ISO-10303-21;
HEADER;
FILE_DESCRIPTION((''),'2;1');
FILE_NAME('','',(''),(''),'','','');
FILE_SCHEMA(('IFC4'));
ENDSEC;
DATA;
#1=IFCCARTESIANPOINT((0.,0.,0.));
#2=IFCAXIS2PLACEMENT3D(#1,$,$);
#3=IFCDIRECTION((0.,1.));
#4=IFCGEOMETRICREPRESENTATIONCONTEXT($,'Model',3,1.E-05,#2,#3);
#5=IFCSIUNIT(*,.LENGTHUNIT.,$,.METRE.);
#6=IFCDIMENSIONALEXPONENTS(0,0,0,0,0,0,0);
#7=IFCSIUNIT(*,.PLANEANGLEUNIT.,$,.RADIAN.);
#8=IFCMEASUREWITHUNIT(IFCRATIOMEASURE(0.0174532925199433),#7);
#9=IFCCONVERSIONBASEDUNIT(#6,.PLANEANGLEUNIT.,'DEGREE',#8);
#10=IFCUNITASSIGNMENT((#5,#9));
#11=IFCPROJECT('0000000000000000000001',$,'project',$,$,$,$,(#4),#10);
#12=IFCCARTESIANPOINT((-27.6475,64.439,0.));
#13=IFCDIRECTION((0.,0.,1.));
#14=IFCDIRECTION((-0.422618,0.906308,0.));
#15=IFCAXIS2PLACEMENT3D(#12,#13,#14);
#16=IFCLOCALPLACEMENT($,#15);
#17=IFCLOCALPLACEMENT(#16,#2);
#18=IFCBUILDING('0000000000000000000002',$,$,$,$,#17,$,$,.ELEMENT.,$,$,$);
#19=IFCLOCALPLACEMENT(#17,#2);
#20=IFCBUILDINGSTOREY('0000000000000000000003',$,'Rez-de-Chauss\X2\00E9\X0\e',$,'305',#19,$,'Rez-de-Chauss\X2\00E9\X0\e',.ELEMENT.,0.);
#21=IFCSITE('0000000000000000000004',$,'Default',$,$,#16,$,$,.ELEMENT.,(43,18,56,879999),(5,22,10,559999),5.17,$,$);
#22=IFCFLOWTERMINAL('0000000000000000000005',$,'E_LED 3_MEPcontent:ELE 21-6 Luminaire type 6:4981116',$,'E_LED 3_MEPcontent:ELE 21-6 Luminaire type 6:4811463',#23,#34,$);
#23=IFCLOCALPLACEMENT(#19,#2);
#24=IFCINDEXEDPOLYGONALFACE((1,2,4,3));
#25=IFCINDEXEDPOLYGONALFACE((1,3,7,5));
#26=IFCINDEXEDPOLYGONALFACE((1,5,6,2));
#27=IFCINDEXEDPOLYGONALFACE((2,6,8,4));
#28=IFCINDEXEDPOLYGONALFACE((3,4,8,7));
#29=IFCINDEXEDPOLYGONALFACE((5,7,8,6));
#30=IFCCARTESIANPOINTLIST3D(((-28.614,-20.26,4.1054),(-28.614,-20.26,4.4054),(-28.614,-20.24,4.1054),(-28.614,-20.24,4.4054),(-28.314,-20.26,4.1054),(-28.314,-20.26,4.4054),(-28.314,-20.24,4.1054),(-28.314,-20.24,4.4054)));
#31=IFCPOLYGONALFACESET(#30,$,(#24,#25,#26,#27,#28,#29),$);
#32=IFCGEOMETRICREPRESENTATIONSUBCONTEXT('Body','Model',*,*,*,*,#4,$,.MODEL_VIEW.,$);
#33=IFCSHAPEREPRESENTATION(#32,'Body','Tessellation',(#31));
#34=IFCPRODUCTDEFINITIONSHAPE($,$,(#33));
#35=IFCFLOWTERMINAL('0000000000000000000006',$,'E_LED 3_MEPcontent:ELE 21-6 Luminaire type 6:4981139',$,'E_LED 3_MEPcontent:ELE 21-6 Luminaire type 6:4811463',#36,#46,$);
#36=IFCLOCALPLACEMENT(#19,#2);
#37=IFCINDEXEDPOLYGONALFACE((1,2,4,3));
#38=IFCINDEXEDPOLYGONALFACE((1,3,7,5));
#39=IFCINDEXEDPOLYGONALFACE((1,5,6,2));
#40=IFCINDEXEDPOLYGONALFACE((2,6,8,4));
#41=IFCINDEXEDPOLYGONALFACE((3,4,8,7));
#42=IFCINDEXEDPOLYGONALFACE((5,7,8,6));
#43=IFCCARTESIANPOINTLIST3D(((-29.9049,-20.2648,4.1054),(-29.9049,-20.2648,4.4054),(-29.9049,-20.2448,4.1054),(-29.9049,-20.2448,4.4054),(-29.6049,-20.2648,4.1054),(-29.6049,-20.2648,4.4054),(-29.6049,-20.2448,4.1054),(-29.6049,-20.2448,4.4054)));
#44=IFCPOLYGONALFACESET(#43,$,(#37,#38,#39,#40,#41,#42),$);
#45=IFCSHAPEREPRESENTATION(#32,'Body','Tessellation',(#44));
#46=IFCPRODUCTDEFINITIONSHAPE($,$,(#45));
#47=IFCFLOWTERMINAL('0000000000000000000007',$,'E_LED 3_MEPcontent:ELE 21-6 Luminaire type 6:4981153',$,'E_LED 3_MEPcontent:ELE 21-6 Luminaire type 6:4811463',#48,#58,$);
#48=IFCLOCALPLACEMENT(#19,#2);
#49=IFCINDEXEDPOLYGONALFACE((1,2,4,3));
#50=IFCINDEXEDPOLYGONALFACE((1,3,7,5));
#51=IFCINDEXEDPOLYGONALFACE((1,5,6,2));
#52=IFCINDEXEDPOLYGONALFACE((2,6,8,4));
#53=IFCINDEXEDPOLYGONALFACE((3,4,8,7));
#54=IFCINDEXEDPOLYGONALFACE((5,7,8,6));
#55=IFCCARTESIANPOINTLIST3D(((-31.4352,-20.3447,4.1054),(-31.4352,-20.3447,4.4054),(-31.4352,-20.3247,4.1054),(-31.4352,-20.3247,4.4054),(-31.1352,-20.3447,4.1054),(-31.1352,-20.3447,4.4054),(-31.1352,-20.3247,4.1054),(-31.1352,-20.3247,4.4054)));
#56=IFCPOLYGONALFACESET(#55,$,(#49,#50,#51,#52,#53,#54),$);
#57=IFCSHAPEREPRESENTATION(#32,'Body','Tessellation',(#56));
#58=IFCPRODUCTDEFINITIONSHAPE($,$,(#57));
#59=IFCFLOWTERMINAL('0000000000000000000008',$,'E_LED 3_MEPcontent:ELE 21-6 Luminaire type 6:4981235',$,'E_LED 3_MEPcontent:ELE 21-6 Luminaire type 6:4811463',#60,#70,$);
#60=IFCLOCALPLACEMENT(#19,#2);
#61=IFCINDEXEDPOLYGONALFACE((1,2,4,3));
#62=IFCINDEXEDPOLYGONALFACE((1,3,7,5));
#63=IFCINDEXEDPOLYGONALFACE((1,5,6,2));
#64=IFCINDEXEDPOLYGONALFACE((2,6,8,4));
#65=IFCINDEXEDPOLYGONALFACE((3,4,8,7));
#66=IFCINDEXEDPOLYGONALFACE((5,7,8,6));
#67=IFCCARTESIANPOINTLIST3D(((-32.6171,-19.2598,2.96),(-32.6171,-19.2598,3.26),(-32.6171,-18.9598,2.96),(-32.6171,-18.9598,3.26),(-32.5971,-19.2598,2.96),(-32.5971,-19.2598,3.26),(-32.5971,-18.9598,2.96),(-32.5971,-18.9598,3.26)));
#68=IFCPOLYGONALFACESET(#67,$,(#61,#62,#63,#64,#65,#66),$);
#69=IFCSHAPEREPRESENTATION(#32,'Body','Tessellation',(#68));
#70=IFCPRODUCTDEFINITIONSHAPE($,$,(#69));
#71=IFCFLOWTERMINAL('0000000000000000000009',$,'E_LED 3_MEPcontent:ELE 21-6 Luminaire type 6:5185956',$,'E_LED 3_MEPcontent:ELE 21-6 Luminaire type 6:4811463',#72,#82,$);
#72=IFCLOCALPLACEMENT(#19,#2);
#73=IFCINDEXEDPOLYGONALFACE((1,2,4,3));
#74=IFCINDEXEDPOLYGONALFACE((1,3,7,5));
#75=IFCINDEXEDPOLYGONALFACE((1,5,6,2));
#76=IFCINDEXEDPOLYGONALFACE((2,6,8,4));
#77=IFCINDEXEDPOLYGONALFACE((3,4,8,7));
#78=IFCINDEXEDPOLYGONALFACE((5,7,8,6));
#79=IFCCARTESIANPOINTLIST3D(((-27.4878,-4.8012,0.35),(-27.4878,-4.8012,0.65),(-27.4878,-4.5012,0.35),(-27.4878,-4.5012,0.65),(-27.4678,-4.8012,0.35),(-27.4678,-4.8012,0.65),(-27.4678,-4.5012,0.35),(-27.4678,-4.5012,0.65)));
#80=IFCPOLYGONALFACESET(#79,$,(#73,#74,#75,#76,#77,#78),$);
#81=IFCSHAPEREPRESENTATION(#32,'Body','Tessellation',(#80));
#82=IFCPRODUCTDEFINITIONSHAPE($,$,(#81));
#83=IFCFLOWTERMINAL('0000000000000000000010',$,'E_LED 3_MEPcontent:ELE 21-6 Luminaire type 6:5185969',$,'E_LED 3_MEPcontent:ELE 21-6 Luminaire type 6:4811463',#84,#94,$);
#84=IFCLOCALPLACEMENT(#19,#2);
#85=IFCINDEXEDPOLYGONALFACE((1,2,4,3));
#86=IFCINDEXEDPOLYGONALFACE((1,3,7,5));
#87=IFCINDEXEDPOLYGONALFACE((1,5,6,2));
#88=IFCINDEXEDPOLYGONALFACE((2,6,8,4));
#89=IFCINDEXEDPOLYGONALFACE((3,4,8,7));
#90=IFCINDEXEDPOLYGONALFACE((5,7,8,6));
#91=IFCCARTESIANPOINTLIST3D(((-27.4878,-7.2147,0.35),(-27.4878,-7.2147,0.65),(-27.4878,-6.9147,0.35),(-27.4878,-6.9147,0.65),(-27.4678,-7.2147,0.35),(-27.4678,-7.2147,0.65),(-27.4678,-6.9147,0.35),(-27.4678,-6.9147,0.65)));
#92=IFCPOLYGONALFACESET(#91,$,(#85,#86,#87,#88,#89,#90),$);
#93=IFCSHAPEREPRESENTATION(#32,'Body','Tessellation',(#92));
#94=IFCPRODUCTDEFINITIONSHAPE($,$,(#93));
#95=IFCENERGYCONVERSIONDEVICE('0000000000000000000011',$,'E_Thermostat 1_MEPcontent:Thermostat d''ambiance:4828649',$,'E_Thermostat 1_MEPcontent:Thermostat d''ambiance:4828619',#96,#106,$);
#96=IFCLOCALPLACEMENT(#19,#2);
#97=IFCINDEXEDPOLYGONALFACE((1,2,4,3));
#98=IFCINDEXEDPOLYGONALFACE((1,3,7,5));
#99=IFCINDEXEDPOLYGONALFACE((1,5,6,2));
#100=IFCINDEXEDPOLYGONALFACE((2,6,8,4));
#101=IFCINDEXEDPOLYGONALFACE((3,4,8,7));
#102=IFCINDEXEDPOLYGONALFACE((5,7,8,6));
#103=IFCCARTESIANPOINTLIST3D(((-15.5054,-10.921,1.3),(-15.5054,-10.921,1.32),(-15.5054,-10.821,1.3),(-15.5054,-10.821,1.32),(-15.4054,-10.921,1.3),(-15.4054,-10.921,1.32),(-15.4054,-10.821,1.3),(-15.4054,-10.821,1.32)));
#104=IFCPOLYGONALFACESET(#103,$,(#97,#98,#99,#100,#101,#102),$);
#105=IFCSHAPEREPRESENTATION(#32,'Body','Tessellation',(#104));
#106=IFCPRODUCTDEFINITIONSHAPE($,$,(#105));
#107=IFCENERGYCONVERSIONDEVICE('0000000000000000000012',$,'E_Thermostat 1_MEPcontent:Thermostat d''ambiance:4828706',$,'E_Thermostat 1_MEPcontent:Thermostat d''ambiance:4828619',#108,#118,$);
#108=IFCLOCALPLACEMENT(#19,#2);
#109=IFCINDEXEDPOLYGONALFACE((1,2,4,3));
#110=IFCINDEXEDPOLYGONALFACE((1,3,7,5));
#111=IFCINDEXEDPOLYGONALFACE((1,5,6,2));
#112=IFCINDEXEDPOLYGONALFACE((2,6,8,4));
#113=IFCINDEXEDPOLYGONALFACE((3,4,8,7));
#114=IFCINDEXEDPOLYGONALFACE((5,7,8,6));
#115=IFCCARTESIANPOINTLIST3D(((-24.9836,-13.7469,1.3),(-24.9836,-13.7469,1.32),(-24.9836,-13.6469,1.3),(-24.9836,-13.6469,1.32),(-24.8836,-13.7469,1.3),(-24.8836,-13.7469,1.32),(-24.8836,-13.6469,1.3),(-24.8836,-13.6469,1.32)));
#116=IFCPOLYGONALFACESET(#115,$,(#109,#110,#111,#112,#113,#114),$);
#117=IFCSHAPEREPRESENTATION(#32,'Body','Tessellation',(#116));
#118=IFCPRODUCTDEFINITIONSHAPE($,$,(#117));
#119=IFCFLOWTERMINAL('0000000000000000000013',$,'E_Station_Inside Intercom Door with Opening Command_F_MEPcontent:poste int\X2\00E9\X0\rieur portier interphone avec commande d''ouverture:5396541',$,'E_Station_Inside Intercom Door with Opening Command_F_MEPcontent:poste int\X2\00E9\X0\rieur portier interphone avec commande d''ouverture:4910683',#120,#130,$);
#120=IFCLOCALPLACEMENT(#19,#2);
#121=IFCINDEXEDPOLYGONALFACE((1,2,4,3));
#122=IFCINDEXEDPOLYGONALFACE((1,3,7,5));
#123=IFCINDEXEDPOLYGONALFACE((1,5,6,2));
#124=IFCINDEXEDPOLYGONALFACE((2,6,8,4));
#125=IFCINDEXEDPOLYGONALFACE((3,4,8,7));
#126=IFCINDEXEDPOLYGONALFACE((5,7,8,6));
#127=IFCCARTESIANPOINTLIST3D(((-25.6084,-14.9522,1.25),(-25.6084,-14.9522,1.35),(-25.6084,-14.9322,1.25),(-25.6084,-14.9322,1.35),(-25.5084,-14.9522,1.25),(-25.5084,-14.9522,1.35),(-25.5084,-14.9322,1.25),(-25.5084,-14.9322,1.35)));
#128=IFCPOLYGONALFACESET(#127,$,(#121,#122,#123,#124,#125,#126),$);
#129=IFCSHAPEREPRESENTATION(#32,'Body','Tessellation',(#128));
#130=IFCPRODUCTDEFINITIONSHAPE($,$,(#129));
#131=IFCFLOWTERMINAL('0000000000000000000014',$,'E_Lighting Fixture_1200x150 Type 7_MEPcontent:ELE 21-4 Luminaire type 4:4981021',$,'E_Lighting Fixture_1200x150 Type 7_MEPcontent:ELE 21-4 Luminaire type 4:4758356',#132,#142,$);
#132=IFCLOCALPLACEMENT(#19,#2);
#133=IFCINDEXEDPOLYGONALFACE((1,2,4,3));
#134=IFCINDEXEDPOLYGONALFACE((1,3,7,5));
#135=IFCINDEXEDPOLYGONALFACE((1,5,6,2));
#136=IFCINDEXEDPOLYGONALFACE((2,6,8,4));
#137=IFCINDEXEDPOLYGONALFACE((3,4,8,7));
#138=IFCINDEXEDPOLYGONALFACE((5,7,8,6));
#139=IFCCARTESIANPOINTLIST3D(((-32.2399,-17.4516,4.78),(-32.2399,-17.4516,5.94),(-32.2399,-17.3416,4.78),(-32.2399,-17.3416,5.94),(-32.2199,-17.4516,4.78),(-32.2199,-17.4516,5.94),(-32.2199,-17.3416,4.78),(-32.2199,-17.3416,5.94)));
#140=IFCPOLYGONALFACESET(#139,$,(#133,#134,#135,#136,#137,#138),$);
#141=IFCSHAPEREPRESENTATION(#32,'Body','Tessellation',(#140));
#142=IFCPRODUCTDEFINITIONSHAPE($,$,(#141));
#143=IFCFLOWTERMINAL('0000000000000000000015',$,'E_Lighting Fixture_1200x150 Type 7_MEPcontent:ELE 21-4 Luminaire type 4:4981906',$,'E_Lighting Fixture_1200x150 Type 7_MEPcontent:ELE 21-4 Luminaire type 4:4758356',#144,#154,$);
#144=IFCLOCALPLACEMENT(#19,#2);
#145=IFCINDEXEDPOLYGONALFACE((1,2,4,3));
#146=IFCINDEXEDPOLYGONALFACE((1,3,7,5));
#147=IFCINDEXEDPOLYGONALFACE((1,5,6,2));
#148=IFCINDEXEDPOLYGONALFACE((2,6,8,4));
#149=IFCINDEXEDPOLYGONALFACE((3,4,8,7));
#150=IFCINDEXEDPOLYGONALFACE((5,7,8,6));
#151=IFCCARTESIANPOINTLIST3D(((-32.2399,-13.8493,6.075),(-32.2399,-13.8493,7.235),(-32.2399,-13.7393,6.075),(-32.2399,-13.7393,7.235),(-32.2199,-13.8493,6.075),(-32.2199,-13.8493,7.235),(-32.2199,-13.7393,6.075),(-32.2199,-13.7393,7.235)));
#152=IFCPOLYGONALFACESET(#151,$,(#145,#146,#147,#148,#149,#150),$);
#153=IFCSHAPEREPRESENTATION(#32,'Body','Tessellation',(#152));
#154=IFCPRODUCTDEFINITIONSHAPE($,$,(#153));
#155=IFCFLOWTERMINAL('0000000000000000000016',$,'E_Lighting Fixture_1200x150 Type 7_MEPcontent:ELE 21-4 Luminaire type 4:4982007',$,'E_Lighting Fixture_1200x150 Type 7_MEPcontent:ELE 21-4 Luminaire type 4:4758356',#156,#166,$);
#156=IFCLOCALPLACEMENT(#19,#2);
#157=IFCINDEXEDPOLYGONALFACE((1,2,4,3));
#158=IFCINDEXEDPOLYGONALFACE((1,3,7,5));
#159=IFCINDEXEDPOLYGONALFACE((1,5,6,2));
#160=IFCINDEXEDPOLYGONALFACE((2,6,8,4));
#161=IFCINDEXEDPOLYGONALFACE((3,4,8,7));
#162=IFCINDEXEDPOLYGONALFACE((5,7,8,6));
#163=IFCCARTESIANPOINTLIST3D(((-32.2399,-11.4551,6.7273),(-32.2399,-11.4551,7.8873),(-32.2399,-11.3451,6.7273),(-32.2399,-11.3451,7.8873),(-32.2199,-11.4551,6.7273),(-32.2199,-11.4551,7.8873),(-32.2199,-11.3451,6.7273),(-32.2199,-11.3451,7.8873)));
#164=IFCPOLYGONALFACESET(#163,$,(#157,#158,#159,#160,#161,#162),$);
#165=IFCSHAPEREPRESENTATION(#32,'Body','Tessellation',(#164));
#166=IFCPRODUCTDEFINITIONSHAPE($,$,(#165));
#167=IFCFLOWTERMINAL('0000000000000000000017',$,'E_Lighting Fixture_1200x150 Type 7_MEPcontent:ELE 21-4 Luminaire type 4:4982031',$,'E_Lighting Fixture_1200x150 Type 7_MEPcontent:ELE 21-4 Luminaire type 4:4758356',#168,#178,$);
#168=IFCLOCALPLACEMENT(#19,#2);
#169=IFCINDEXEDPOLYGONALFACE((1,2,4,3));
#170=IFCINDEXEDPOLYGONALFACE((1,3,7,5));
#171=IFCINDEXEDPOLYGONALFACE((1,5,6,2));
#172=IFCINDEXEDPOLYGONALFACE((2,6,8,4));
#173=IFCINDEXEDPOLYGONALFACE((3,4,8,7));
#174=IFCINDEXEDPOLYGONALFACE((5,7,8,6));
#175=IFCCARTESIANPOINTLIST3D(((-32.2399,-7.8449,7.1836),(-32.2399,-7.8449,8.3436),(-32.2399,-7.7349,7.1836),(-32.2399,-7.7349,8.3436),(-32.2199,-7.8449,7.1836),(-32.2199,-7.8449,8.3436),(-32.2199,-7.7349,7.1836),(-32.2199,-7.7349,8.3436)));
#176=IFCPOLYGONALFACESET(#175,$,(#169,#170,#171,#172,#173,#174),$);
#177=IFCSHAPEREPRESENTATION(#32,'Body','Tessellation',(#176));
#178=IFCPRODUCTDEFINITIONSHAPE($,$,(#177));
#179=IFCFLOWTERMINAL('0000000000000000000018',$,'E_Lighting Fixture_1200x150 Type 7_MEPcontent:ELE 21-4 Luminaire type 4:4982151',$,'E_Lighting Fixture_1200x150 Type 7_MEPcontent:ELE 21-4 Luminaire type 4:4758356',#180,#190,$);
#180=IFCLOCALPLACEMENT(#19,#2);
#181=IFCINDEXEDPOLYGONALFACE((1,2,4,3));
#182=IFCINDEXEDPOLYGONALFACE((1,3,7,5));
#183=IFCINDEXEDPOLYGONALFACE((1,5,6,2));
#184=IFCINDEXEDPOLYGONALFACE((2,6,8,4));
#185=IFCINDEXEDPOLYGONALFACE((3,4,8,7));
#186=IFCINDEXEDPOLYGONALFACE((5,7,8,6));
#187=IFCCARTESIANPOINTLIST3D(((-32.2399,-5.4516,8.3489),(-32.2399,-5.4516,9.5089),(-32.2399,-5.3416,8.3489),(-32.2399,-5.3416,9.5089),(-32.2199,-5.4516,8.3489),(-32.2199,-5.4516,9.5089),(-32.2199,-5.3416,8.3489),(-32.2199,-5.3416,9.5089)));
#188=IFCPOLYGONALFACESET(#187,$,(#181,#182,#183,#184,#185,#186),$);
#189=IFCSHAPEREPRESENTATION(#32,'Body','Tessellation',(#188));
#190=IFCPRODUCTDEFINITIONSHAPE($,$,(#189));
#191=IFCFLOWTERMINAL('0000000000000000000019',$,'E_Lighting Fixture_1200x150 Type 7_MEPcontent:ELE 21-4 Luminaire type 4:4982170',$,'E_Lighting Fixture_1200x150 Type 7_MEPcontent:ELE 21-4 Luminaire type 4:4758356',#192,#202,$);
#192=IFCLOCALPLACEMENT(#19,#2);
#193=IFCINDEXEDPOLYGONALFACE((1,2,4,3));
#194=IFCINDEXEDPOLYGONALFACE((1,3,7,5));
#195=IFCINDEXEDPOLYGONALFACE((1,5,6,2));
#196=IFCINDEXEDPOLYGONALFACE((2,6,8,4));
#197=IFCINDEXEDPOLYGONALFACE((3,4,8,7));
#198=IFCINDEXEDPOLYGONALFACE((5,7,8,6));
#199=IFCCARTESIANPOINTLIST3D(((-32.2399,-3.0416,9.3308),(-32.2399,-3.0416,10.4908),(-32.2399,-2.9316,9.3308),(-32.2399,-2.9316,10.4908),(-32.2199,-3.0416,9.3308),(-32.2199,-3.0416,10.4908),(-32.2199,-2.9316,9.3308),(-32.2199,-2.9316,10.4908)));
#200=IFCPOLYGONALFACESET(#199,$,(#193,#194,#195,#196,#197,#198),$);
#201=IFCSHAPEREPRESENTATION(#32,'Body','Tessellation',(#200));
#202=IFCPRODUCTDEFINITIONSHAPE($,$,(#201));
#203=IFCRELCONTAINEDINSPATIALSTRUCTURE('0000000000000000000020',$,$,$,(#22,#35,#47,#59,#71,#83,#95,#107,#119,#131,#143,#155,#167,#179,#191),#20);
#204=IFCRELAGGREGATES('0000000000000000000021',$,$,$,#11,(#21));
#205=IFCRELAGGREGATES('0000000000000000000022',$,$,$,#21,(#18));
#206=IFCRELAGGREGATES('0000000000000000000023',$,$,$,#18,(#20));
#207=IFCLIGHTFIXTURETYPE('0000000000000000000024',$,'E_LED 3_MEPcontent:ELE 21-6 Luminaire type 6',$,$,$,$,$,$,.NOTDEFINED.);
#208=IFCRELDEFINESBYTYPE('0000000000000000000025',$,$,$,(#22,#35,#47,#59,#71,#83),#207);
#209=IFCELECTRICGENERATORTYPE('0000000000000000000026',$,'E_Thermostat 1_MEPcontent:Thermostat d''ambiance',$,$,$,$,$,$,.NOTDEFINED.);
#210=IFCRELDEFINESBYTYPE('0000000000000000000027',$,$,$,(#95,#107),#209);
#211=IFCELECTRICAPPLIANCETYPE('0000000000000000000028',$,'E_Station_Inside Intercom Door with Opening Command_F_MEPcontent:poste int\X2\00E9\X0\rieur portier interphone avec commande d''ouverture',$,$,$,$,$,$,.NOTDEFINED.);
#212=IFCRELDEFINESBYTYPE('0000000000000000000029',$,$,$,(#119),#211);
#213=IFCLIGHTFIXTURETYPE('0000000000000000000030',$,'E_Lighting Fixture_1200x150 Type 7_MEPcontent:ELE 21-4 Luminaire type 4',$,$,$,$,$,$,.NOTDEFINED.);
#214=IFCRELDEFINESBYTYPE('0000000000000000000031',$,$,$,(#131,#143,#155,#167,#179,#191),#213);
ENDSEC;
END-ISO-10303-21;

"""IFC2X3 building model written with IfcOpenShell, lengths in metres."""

from ifc_helpers import new_model, entity, si_unit, converted_unit, direction, frame, frame_2d, origin, origin_2d_with_axis, place, context, subcontext, project, spatial, rectangle, extrude, source, transform, mapped, type_object, type_shapes, element, save


model = new_model("IFC2X3")

# Units and contexts
model_context = context("Model", 3, precision=1e-05, world=origin(), true_north=direction((0.0, 1.0)))
body_context = subcontext(model_context, "Body", "Model", "MODEL_VIEW")
ifc_project = project(units=[si_unit("LENGTHUNIT", "METRE"), converted_unit("PLANEANGLEUNIT", "DEGREE", entity("IfcRatioMeasure", 0.0174532925199433), si_unit("PLANEANGLEUNIT", "RADIAN"), dimensions=[0, 0, 0, 0, 0, 0, 0])], contexts=[model_context])

# Site, building, storey
site_placement = place(None, frame((-27.6475, 64.439, 0.0), z_axis=(0.0, 0.0, 1.0), x_axis=(-0.422618, 0.906308, 0.0)))
site = spatial("IfcSite", under=ifc_project, at=site_placement, Name="Default", CompositionType="ELEMENT", RefLatitude=(43, 18, 56, 879999), RefLongitude=(5, 22, 10, 559999), RefElevation=5.17)
building_placement = place(site_placement, origin())
building = spatial("IfcBuilding", under=site, at=building_placement, CompositionType="ELEMENT")
storey_placement = place(building_placement, origin())
storey = spatial("IfcBuildingStorey", under=building, at=storey_placement, Name="Rez-de-Chaussée", ObjectType="305", LongName="Rez-de-Chaussée", CompositionType="ELEMENT", Elevation=0.0)

# Flow terminals
light_fixture_type_1 = type_object("IfcLightFixtureType", Name="E_LED 3_MEPcontent:ELE 21-6 Luminaire type 6", PredefinedType="NOTDEFINED")
shared_shape_1 = source(origin(), body_context, "Body", "SweptSolid", [
    extrude(rectangle(XDim=0.02, YDim=0.3, at=origin_2d_with_axis()), frame((0.0, 0.01, -0.15), z_axis=(0.0, 0.0, 1.0), x_axis=(0.0, -1.0, 0.0)), (0.0, 0.0, 1.0), 0.3),
])
type_shapes(light_fixture_type_1, [shared_shape_1])
for number, where, z_axis, x_axis, name in (
    (1, (-28.464, -20.24, 4.2554), (0.0, 0.0, 1.0), (-1.0, 0.0, 0.0), "E_LED 3_MEPcontent:ELE 21-6 Luminaire type 6:4981116"),
    (2, (-29.7549, -20.2448, 4.2554), (0.0, 0.0, 1.0), (-1.0, 0.0, 0.0), "E_LED 3_MEPcontent:ELE 21-6 Luminaire type 6:4981139"),
    (3, (-31.2852, -20.3247, 4.2554), (0.0, 0.0, 1.0), (-1.0, 0.0, 0.0), "E_LED 3_MEPcontent:ELE 21-6 Luminaire type 6:4981153"),
    (4, (-32.6171, -19.1098, 3.11), (0.0, 0.0, 1.0), (0.0, -1.0, 0.0), "E_LED 3_MEPcontent:ELE 21-6 Luminaire type 6:4981235"),
    (5, (-27.4878, -4.6512, 0.5), (0.0, 0.0, 1.0), (0.0, -1.0, 0.0), "E_LED 3_MEPcontent:ELE 21-6 Luminaire type 6:5185956"),
    (6, (-27.4878, -7.0647, 0.5), (0.0, 0.0, 1.0), (0.0, -1.0, 0.0), "E_LED 3_MEPcontent:ELE 21-6 Luminaire type 6:5185969"),
):
    element("IfcFlowTerminal", number, at=place(storey_placement, frame(where, z_axis=z_axis, x_axis=x_axis)), inside=storey, type_object=light_fixture_type_1, Name=name, ObjectType="E_LED 3_MEPcontent:ELE 21-6 Luminaire type 6:4811463", context=body_context, shape_type="MappedRepresentation", body=[
        mapped(shared_shape_1, transform((0.0, 0.0, 0.0), scale=1.0)),
    ])

# Energy conversion devices
electric_generator_type_1 = type_object("IfcElectricGeneratorType", Name="E_Thermostat 1_MEPcontent:Thermostat d'ambiance", PredefinedType="NOTDEFINED")
shared_shape_2 = source(origin(), body_context, "Body", "SweptSolid", [
    extrude(rectangle(XDim=0.1, YDim=0.1, at=origin_2d_with_axis()), frame((0.0, 0.0, 0.0), z_axis=(0.0, 0.0, 1.0), x_axis=(0.0, -1.0, 0.0)), (0.0, 0.0, 1.0), 0.02),
])
type_shapes(electric_generator_type_1, [shared_shape_2])
for number, where, z_axis, x_axis, name in (
    (7, (-15.4554, -10.871, 1.3), (0.0, 0.0, 1.0), (0.0, -1.0, 0.0), "E_Thermostat 1_MEPcontent:Thermostat d'ambiance:4828649"),
    (8, (-24.9336, -13.6969, 1.3), (0.0, 0.0, 1.0), (0.0, 1.0, 0.0), "E_Thermostat 1_MEPcontent:Thermostat d'ambiance:4828706"),
):
    element("IfcEnergyConversionDevice", number, at=place(storey_placement, frame(where, z_axis=z_axis, x_axis=x_axis)), inside=storey, type_object=electric_generator_type_1, Name=name, ObjectType="E_Thermostat 1_MEPcontent:Thermostat d'ambiance:4828619", context=body_context, shape_type="MappedRepresentation", body=[
        mapped(shared_shape_2, transform((0.0, 0.0, 0.0), scale=1.0)),
    ])

# Flow terminals
electric_appliance_type_1 = type_object("IfcElectricApplianceType", Name="E_Station_Inside Intercom Door with Opening Command_F_MEPcontent:poste intérieur portier interphone avec commande d'ouverture", PredefinedType="NOTDEFINED")
shared_shape_3 = source(origin(), body_context, "Body", "SweptSolid", [
    extrude(rectangle(XDim=0.1, YDim=0.1, at=origin_2d_with_axis()), frame((0.0, 0.0, 0.0), z_axis=(0.0, 0.0, 1.0), x_axis=(0.0, 1.0, 0.0)), (0.0, 0.0, 1.0), 0.02),
])
type_shapes(electric_appliance_type_1, [shared_shape_3])
flow_terminal_1_placement = place(storey_placement, frame((-25.5584, -14.9522, 1.3), z_axis=(0.0, 1.0, 0.0), x_axis=(-1.0, 0.0, 0.0)))
element("IfcFlowTerminal", 9, at=flow_terminal_1_placement, inside=storey, type_object=electric_appliance_type_1, Name="E_Station_Inside Intercom Door with Opening Command_F_MEPcontent:poste intérieur portier interphone avec commande d'ouverture:5396541", ObjectType="E_Station_Inside Intercom Door with Opening Command_F_MEPcontent:poste intérieur portier interphone avec commande d'ouverture:4910683", context=body_context, shape_type="MappedRepresentation", body=[
    mapped(shared_shape_3, transform((0.0, 0.0, 0.0), scale=1.0)),
])
light_fixture_type_2 = type_object("IfcLightFixtureType", Name="E_Lighting Fixture_1200x150 Type 7_MEPcontent:ELE 21-4 Luminaire type 4", PredefinedType="NOTDEFINED")
shared_shape_4 = source(origin(), body_context, "Body", "SweptSolid", [
    extrude(rectangle(XDim=0.02, YDim=0.11, at=frame_2d((0.0, 0.0), x_axis=(1.0, 0.0))), frame((0.01, 0.0, -0.58), z_axis=(0.0, 0.0, 1.0), x_axis=(-1.0, 0.0, 0.0)), (0.0, 0.0, 1.0), 1.16),
])
type_shapes(light_fixture_type_2, [shared_shape_4])
for number, where, name in (
    (10, (-32.2399, -17.3966, 5.36), "E_Lighting Fixture_1200x150 Type 7_MEPcontent:ELE 21-4 Luminaire type 4:4981021"),
    (11, (-32.2399, -13.7943, 6.655), "E_Lighting Fixture_1200x150 Type 7_MEPcontent:ELE 21-4 Luminaire type 4:4981906"),
    (12, (-32.2399, -11.4001, 7.3073), "E_Lighting Fixture_1200x150 Type 7_MEPcontent:ELE 21-4 Luminaire type 4:4982007"),
    (13, (-32.2399, -7.7899, 7.7636), "E_Lighting Fixture_1200x150 Type 7_MEPcontent:ELE 21-4 Luminaire type 4:4982031"),
    (14, (-32.2399, -5.3966, 8.9289), "E_Lighting Fixture_1200x150 Type 7_MEPcontent:ELE 21-4 Luminaire type 4:4982151"),
    (15, (-32.2399, -2.9866, 9.9108), "E_Lighting Fixture_1200x150 Type 7_MEPcontent:ELE 21-4 Luminaire type 4:4982170"),
):
    element("IfcFlowTerminal", number, at=place(storey_placement, frame(where)), inside=storey, type_object=light_fixture_type_2, Name=name, ObjectType="E_Lighting Fixture_1200x150 Type 7_MEPcontent:ELE 21-4 Luminaire type 4:4758356", context=body_context, shape_type="MappedRepresentation", body=[
        mapped(shared_shape_4, transform((0.0, 0.0, 0.0), scale=1.0)),
    ])

save(model, "model.ifc")
